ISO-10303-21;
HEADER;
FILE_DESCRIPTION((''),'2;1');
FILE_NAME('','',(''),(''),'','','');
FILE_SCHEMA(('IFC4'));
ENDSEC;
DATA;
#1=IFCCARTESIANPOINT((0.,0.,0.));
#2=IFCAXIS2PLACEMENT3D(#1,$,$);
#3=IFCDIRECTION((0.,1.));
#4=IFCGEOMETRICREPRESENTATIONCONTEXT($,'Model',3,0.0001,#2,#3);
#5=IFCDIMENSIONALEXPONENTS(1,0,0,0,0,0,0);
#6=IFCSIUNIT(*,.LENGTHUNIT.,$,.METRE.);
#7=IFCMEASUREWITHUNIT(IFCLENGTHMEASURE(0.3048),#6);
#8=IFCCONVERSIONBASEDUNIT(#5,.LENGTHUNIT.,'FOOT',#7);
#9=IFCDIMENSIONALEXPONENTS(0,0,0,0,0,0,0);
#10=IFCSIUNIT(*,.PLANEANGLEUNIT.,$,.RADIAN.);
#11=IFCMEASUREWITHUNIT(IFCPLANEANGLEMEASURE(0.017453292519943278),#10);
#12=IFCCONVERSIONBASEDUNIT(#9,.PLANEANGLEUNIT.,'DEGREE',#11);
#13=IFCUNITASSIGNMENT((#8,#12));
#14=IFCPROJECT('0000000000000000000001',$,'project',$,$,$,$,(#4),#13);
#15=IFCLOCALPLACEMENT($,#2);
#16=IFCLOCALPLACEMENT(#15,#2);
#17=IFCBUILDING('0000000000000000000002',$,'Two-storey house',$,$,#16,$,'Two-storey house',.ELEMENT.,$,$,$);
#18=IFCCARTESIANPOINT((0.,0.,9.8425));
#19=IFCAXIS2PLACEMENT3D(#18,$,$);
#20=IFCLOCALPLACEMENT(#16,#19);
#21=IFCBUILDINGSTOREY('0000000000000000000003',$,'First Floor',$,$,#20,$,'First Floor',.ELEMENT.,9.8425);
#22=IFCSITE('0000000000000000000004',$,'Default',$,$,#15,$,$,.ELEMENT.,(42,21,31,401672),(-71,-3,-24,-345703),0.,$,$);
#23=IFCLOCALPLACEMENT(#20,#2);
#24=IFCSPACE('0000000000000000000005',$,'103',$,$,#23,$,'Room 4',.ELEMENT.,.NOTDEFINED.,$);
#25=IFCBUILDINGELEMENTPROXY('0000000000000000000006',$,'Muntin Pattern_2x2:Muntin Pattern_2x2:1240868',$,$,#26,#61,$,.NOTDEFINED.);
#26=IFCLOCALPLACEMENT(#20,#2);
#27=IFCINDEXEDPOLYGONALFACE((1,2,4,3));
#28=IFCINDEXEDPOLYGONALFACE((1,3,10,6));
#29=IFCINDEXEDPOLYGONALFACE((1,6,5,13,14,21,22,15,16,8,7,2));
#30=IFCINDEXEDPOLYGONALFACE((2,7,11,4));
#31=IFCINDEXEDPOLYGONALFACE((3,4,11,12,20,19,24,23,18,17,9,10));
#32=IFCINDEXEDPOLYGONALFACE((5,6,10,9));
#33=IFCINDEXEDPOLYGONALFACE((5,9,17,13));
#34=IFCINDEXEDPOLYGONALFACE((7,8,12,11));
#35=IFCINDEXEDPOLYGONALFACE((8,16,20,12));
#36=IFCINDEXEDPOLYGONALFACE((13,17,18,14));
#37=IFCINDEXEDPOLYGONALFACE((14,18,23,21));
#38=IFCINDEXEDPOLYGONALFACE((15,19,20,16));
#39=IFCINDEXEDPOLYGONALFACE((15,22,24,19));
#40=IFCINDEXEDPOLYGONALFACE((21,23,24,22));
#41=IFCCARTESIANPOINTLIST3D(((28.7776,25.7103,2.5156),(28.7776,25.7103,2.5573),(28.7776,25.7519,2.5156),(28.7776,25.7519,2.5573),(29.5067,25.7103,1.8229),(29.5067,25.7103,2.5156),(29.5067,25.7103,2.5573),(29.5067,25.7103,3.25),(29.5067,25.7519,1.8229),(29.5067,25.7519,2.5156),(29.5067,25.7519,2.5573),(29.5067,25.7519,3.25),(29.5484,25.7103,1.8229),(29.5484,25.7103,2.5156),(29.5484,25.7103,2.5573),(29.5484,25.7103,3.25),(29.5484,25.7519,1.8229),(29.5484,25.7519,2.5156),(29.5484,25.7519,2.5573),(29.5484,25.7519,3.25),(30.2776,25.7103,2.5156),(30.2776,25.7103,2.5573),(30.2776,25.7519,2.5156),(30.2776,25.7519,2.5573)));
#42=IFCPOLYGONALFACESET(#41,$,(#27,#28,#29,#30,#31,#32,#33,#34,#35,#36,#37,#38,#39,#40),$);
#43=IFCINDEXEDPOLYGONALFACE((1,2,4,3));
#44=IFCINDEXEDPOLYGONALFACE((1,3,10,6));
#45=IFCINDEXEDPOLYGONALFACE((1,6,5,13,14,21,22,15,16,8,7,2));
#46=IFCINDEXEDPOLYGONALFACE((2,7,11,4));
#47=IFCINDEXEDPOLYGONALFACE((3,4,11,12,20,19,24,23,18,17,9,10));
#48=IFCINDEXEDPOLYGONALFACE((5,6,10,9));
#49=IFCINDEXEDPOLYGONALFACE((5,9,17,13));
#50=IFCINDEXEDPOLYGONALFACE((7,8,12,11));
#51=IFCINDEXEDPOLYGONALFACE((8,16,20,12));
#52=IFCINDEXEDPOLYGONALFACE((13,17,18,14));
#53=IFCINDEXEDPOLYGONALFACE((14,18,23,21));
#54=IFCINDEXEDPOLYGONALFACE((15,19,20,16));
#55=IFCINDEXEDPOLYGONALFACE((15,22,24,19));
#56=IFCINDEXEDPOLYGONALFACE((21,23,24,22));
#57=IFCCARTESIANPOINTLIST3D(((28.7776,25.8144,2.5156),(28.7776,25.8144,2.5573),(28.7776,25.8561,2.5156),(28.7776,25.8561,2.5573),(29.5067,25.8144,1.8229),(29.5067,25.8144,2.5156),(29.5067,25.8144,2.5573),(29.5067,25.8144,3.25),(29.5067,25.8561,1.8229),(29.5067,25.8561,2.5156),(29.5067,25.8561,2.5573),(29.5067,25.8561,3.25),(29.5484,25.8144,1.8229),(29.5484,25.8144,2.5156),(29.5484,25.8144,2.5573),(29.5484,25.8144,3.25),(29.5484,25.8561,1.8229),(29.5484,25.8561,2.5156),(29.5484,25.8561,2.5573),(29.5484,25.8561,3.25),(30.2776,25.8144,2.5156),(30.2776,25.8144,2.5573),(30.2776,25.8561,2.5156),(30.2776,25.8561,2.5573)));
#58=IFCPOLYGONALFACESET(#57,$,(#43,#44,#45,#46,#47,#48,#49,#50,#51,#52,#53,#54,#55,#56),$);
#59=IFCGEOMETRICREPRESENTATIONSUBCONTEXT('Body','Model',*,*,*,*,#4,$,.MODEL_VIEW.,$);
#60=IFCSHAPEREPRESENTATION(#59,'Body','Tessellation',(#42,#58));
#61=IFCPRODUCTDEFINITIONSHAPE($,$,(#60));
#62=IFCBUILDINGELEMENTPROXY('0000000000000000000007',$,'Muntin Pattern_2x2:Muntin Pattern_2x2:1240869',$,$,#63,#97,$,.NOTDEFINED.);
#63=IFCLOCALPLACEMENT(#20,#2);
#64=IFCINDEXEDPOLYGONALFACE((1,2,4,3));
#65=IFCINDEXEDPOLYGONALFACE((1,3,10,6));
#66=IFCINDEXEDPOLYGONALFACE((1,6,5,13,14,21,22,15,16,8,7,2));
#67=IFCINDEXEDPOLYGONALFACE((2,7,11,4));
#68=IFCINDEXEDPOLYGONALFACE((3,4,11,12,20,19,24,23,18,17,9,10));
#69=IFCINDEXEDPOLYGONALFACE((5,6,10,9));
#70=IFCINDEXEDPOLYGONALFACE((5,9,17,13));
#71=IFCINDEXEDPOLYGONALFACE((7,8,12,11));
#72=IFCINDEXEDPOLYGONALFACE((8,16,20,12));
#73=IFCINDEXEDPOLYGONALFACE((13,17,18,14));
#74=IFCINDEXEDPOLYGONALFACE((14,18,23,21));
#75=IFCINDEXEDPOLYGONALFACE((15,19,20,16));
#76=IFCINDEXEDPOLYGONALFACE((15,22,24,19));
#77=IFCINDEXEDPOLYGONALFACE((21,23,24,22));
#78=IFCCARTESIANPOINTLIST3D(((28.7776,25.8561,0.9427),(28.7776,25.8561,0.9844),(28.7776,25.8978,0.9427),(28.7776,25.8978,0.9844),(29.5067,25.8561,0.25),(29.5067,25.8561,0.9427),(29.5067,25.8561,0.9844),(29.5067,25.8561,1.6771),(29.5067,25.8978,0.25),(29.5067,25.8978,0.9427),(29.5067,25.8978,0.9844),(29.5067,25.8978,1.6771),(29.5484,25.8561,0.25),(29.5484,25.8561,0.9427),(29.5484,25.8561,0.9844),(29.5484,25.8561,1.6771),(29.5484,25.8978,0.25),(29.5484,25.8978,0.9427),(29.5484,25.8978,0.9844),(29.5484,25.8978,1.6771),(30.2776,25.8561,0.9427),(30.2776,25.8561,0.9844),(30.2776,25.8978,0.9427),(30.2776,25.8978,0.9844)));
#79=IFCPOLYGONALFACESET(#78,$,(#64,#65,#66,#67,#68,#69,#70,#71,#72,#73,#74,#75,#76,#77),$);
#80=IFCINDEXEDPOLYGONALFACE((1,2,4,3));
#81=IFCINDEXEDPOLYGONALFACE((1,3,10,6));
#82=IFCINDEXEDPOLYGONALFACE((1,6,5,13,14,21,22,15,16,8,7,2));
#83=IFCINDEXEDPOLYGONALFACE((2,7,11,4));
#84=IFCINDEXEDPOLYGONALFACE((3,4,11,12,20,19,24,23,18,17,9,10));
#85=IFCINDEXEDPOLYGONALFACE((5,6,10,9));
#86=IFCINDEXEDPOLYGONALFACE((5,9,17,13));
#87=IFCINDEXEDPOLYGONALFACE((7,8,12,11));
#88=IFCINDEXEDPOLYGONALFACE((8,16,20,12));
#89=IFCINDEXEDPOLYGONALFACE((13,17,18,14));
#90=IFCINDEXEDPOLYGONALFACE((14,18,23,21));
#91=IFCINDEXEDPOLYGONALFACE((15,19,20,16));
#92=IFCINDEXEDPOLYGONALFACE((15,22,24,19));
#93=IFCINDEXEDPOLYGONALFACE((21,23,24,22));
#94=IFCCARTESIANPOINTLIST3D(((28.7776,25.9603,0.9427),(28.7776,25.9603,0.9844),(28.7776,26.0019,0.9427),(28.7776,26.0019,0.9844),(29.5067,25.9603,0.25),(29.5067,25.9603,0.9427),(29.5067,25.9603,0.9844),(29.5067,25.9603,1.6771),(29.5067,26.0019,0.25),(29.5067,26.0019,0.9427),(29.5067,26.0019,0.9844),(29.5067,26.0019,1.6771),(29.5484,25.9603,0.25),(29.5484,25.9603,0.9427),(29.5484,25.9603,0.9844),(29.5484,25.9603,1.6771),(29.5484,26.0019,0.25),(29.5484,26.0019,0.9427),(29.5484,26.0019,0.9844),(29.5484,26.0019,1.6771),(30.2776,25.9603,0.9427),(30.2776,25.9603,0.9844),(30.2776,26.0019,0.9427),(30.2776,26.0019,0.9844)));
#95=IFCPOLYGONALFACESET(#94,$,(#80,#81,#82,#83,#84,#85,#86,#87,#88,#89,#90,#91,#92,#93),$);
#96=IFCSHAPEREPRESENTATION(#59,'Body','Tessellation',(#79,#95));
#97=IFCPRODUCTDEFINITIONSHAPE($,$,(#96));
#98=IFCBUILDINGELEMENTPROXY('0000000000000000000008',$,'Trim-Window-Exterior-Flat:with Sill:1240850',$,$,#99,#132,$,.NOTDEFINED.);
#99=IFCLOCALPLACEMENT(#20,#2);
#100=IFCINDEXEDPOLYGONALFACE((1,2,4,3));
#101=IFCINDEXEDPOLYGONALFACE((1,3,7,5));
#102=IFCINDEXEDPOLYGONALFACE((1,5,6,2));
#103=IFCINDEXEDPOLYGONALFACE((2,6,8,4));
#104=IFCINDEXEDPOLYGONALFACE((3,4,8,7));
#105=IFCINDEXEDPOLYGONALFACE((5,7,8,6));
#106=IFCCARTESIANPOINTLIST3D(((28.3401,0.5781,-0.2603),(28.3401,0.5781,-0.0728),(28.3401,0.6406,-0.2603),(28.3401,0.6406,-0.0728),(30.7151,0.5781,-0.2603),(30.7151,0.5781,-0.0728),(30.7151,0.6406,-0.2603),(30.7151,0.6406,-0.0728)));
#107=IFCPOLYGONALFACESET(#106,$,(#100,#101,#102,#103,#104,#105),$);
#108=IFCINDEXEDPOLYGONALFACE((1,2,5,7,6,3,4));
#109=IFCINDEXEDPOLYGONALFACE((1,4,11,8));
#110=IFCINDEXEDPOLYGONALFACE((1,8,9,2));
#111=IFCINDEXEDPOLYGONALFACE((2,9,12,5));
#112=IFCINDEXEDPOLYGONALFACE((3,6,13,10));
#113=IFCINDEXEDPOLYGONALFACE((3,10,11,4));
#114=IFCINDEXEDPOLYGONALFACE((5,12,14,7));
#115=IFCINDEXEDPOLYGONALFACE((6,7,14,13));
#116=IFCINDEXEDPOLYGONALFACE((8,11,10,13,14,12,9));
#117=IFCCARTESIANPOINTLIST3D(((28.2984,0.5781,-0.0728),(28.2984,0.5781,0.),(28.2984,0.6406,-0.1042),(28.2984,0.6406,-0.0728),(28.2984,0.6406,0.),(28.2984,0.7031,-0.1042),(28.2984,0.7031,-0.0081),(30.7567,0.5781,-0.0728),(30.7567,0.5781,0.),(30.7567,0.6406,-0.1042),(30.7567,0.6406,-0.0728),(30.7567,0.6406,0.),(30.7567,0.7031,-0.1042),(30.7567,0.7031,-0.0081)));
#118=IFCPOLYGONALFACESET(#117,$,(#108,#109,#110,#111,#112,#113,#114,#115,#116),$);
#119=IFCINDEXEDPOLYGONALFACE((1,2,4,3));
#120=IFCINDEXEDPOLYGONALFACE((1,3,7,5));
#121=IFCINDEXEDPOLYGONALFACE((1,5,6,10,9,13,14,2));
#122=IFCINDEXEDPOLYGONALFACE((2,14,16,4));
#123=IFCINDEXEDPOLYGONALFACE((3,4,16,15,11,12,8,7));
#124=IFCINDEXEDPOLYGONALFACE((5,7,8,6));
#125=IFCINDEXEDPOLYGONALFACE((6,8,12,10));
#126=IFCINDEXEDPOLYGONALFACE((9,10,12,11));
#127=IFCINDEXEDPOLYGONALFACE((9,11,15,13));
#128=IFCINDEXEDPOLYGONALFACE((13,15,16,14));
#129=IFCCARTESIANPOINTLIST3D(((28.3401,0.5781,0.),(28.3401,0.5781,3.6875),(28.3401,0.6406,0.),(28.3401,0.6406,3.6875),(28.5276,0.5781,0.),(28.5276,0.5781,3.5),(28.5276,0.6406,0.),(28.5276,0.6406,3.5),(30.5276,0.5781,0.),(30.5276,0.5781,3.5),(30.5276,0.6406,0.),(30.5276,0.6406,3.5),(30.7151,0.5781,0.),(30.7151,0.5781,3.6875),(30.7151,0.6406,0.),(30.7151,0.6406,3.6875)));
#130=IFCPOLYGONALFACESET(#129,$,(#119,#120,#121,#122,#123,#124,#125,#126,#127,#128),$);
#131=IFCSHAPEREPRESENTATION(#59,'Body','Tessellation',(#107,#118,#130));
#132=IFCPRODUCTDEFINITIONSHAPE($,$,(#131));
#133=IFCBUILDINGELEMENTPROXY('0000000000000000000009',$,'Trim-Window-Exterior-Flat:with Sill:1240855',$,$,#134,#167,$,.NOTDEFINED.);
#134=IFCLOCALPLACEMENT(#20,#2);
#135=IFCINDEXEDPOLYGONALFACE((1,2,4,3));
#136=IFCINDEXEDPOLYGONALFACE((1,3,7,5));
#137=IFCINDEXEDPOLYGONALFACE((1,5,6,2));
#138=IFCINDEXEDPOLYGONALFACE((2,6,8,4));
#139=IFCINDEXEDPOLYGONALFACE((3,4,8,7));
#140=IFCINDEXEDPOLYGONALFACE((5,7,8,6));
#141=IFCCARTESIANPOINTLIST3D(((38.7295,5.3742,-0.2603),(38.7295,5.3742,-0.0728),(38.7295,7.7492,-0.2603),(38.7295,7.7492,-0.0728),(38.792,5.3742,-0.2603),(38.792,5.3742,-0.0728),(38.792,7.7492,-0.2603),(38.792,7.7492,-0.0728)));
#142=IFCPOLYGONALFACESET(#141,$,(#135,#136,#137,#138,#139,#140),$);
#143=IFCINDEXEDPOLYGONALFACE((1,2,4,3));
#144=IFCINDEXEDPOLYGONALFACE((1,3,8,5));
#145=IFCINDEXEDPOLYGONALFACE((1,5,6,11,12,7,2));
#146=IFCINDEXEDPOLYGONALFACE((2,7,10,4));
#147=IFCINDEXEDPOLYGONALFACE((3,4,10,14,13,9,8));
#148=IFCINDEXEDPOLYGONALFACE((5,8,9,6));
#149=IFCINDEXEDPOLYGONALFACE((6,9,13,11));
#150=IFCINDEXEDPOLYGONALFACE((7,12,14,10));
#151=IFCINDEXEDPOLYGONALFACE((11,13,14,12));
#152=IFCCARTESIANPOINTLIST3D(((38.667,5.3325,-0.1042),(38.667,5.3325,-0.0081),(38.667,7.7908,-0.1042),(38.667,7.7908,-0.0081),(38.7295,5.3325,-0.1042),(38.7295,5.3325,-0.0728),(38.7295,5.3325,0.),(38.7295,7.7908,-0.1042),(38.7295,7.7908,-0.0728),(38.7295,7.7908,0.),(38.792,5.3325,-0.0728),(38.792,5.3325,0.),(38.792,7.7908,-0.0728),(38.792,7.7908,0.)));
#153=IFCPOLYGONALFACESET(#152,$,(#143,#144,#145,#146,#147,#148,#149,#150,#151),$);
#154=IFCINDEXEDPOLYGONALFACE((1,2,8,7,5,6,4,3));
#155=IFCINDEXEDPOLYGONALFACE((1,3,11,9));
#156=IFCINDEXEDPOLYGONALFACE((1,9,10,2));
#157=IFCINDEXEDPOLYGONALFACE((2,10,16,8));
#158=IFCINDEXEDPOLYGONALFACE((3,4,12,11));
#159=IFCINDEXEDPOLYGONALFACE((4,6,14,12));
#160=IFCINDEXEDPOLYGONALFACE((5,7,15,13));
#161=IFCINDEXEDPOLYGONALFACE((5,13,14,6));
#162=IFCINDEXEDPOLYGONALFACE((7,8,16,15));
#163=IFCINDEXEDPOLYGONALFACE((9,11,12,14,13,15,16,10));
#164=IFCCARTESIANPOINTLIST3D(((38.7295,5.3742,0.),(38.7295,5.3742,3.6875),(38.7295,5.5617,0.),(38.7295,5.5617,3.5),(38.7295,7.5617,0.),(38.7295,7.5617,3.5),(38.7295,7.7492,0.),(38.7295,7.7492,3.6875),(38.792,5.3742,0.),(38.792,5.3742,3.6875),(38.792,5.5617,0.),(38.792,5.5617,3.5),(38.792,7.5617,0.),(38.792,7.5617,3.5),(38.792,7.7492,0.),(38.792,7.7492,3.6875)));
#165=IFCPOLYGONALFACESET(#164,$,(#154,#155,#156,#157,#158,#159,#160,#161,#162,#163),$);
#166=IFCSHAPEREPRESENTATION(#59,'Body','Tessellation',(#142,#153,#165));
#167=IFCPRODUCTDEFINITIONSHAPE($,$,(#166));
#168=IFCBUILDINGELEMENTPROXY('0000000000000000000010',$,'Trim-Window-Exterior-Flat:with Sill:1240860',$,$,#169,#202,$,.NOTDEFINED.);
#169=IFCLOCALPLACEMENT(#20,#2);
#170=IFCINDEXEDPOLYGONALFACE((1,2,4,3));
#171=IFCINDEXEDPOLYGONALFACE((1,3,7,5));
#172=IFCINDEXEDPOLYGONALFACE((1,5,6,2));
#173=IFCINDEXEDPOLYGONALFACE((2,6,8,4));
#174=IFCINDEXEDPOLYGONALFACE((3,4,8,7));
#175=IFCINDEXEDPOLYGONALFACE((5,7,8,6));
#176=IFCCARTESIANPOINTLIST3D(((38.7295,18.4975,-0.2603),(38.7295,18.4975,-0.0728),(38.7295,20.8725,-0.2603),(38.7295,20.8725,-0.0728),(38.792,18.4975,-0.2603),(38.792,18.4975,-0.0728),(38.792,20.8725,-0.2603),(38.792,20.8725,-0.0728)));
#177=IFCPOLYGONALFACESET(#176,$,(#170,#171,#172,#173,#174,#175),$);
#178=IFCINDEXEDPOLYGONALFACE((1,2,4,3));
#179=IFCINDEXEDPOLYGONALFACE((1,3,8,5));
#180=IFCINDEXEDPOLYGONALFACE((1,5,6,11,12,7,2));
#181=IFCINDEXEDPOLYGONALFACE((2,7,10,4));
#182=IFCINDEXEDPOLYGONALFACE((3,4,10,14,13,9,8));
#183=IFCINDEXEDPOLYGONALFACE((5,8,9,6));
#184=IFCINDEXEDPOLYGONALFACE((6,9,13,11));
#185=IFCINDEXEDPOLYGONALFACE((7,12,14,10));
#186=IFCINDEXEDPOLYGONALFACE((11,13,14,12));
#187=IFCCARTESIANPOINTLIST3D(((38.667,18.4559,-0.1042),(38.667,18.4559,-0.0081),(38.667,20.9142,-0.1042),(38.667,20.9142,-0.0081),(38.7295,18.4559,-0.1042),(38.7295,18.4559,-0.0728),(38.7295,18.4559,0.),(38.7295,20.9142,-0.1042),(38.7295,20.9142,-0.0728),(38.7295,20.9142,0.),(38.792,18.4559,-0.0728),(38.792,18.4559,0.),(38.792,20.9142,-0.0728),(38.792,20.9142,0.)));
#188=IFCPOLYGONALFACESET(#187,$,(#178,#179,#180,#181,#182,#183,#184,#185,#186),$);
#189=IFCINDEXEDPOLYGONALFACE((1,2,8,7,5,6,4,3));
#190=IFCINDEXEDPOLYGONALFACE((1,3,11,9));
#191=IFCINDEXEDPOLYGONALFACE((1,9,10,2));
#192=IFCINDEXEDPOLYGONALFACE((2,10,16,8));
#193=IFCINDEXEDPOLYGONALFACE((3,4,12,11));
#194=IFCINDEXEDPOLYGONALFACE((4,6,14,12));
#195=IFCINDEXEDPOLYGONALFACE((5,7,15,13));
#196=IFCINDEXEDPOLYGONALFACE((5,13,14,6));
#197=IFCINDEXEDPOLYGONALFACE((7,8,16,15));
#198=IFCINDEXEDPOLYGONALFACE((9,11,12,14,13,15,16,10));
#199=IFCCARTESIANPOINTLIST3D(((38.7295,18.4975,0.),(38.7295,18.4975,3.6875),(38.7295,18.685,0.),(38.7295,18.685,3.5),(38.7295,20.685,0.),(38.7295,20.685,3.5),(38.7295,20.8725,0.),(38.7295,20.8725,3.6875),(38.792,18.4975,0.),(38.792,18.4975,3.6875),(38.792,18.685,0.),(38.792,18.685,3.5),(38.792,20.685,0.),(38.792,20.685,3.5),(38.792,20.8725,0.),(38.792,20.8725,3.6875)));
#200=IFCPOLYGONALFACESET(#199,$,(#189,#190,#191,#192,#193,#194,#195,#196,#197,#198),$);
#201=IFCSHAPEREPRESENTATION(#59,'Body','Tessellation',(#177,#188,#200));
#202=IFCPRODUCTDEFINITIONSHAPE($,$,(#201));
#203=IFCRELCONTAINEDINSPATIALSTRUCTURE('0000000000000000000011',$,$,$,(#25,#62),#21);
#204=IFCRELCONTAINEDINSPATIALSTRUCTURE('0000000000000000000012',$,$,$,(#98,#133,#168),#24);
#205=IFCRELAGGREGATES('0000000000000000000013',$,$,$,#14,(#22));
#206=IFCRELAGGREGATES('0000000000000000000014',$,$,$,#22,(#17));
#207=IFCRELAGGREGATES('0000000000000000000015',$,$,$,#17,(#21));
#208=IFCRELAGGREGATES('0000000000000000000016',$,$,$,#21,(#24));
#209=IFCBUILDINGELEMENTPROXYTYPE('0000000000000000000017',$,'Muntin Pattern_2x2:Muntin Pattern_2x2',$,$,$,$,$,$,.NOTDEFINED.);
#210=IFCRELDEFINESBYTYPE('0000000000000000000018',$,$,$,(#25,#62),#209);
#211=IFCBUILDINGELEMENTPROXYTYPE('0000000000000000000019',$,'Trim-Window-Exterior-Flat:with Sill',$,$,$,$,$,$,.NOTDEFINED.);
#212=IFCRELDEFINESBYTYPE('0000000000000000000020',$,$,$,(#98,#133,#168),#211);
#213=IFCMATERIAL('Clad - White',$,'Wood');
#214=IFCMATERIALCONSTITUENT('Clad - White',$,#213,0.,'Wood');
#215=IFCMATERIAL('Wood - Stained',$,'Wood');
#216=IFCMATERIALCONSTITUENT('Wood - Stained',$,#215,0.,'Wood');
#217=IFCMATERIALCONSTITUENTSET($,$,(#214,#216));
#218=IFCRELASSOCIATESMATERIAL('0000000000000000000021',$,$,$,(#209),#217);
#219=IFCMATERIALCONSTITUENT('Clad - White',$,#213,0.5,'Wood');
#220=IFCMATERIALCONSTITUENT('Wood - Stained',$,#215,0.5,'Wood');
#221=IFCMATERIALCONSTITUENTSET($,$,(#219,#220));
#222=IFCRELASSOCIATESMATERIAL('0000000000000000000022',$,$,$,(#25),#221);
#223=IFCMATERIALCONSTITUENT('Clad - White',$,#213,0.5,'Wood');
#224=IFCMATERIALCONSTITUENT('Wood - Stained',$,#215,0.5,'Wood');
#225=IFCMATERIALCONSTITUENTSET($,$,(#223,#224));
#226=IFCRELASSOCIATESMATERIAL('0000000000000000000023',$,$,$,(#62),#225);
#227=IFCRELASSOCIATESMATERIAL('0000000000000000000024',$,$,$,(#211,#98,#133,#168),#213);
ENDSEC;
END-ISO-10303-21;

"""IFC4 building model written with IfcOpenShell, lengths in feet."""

from ifc_helpers import new_model, entity, si_unit, converted_unit, direction, frame, origin, place, context, subcontext, project, spatial, indexed_curve, outline, extrude, source, transform, mapped, material, constituent, constituent_set, type_object, type_shapes, element, save


model = new_model("IFC4")

# Units and contexts
model_context = context("Model", 3, precision=0.0001, world=origin(), true_north=direction((0.0, 1.0)))
body_context = subcontext(model_context, "Body", "Model", "MODEL_VIEW")
ifc_project = project(units=[converted_unit("LENGTHUNIT", "FOOT", entity("IfcLengthMeasure", 0.3048), si_unit("LENGTHUNIT", "METRE"), dimensions=[1, 0, 0, 0, 0, 0, 0]), converted_unit("PLANEANGLEUNIT", "DEGREE", entity("IfcPlaneAngleMeasure", 0.017453292519943278), si_unit("PLANEANGLEUNIT", "RADIAN"), dimensions=[0, 0, 0, 0, 0, 0, 0])], contexts=[model_context])

# Site, building, storey
site_placement = place(None, origin())
site = spatial("IfcSite", under=ifc_project, at=site_placement, Name="Default", CompositionType="ELEMENT", RefLatitude=(42, 21, 31, 401672), RefLongitude=(-71, -3, -24, -345703), RefElevation=0.0)
building_placement = place(site_placement, origin())
building = spatial("IfcBuilding", under=site, at=building_placement, Name="Two-storey house", LongName="Two-storey house", CompositionType="ELEMENT")
storey_placement = place(building_placement, frame((0.0, 0.0, 9.8425)))
storey = spatial("IfcBuildingStorey", under=building, at=storey_placement, Name="First Floor", LongName="First Floor", CompositionType="ELEMENT", Elevation=9.8425)

# Shared definitions
ifc_material_1 = material(Name="Wood - Stained", Category="Wood")

# Building element proxies
ifc_material_2 = material(Name="Clad - White", Category="Wood")
ifc_constituent_1 = constituent(ifc_material_2, Name="Clad - White", Category="Wood", fraction=0.0)
ifc_constituent_2 = constituent(ifc_material_1, Name="Wood - Stained", Category="Wood", fraction=0.0)
ifc_constituent_set_1 = constituent_set(constituents=[ifc_constituent_1, ifc_constituent_2])
building_element_proxy_type_1 = type_object("IfcBuildingElementProxyType", Name="Muntin Pattern_2x2:Muntin Pattern_2x2", PredefinedType="NOTDEFINED", material=ifc_constituent_set_1)
shared_shape_1 = source(origin(), body_context, "Body", "SweptSolid", [
    extrude(outline(indexed_curve([(0.0208, -0.0208), (0.7135, -0.0208), (0.7135, 0.0208), (0.0208, 0.0208), (0.0208, 0.75), (-0.0208, 0.75), (-0.0208, 0.0208), (-0.7135, 0.0208), (-0.7135, -0.0208), (-0.0208, -0.0208), (-0.0208, -0.75), (0.0208, -0.75), (0.0208, -0.0208)], self_intersect=False)), frame((0.0, 0.0312, 0.7135), z_axis=(0.0, 1.0, 0.0), x_axis=(0.0, 0.0, 1.0)), (0.0, 0.0, 1.0), 0.0417),
    extrude(outline(indexed_curve([(0.0208, -0.0208), (0.7135, -0.0208), (0.7135, 0.0208), (0.0208, 0.0208), (0.0208, 0.75), (-0.0208, 0.75), (-0.0208, 0.0208), (-0.7135, 0.0208), (-0.7135, -0.0208), (-0.0208, -0.0208), (-0.0208, -0.75), (0.0208, -0.75), (0.0208, -0.0208)], self_intersect=False)), frame((0.0, -0.0729, 0.7135), z_axis=(0.0, 1.0, 0.0), x_axis=(0.0, 0.0, 1.0)), (0.0, 0.0, 1.0), 0.0417),
])
type_shapes(building_element_proxy_type_1, [shared_shape_1])
ifc_constituent_3 = constituent(ifc_material_2, Name="Clad - White", Category="Wood", fraction=0.5)
ifc_constituent_4 = constituent(ifc_material_1, Name="Wood - Stained", Category="Wood", fraction=0.5)
ifc_constituent_set_2 = constituent_set(constituents=[ifc_constituent_3, ifc_constituent_4])
proxy_1_placement = place(storey_placement, frame((29.5276, 25.7832, 1.8229), z_axis=(0.0, 0.0, 1.0), x_axis=(-1.0, 0.0, 0.0)))
element("IfcBuildingElementProxy", 1, at=proxy_1_placement, inside=storey, type_object=building_element_proxy_type_1, material=ifc_constituent_set_2, Name="Muntin Pattern_2x2:Muntin Pattern_2x2:1240868", PredefinedType="NOTDEFINED", context=body_context, shape_type="MappedRepresentation", body=[
    mapped(shared_shape_1, transform((0.0, 0.0, 0.0), scale=1.0)),
])
ifc_constituent_5 = constituent(ifc_material_2, Name="Clad - White", Category="Wood", fraction=0.5)
ifc_constituent_6 = constituent(ifc_material_1, Name="Wood - Stained", Category="Wood", fraction=0.5)
ifc_constituent_set_3 = constituent_set(constituents=[ifc_constituent_5, ifc_constituent_6])
proxy_2_placement = place(storey_placement, frame((29.5276, 25.929, 0.25), z_axis=(0.0, 0.0, 1.0), x_axis=(-1.0, 0.0, 0.0)))
element("IfcBuildingElementProxy", 2, at=proxy_2_placement, inside=storey, type_object=building_element_proxy_type_1, material=ifc_constituent_set_3, Name="Muntin Pattern_2x2:Muntin Pattern_2x2:1240869", PredefinedType="NOTDEFINED", context=body_context, shape_type="MappedRepresentation", body=[
    mapped(shared_shape_1, transform((0.0, 0.0, 0.0), scale=1.0)),
])

# Shared definitions
space_placement = place(storey_placement, origin())
space = spatial("IfcSpace", under=storey, at=space_placement, Name="103", LongName="Room 4", CompositionType="ELEMENT", PredefinedType="NOTDEFINED")

# Building element proxies
building_element_proxy_type_2 = type_object("IfcBuildingElementProxyType", Name="Trim-Window-Exterior-Flat:with Sill", PredefinedType="NOTDEFINED", material=ifc_material_2)
shared_shape_2 = source(origin(), body_context, "Body", "SweptSolid", [
    extrude(outline(indexed_curve([(-1.1875, -0.0938), (1.1875, -0.0938), (1.1875, 0.0938), (-1.1875, 0.0938), (-1.1875, -0.0938)], self_intersect=False)), frame((0.0, -3.6665, 0.0), z_axis=(0.0, 0.0, 1.0), x_axis=(-1.0, 0.0, 0.0)), (0.0, 0.0, 1.0), 0.0625),
    extrude(outline(indexed_curve([(-0.0625, -0.0525), (0.0, -0.0525), (0.0, -0.0211), (0.0625, -0.0211), (0.0625, 0.0517), (0.0, 0.0517), (-0.0625, 0.0436), (-0.0625, -0.0525)], self_intersect=False)), frame((-1.2292, -3.5517, 0.0625), z_axis=(1.0, 0.0, 0.0), x_axis=(0.0, 0.0, -1.0)), (0.0, 0.0, 1.0), 2.4583),
    extrude(outline(indexed_curve([(-1.8906, -1.1875), (1.7969, -1.1875), (1.7969, -1.0), (-1.7031, -1.0), (-1.7031, 1.0), (1.7969, 1.0), (1.7969, 1.1875), (-1.8906, 1.1875), (-1.8906, -1.1875)], self_intersect=False)), frame((0.0, -1.7031, 0.0), z_axis=(0.0, 0.0, 1.0), x_axis=(0.0, -1.0, 0.0)), (0.0, 0.0, 1.0), 0.0625),
])
type_shapes(building_element_proxy_type_2, [shared_shape_2])
for number, where, z_axis, x_axis, name in (
    (3, (29.5276, 0.5781, 3.5), (0.0, 1.0, 0.0), (-1.0, 0.0, 0.0), "Trim-Window-Exterior-Flat:with Sill:1240850"),
    (4, (38.792, 6.5617, 3.5), (-1.0, 0.0, 0.0), (0.0, -1.0, 0.0), "Trim-Window-Exterior-Flat:with Sill:1240855"),
    (5, (38.792, 19.685, 3.5), (-1.0, 0.0, 0.0), (0.0, -1.0, 0.0), "Trim-Window-Exterior-Flat:with Sill:1240860"),
):
    element("IfcBuildingElementProxy", number, at=place(space_placement, frame(where, z_axis=z_axis, x_axis=x_axis)), inside=space, type_object=building_element_proxy_type_2, material=ifc_material_2, Name=name, PredefinedType="NOTDEFINED", context=body_context, shape_type="MappedRepresentation", body=[
        mapped(shared_shape_2, transform((0.0, 0.0, 0.0), scale=1.0)),
    ])

save(model, "model.ifc")
